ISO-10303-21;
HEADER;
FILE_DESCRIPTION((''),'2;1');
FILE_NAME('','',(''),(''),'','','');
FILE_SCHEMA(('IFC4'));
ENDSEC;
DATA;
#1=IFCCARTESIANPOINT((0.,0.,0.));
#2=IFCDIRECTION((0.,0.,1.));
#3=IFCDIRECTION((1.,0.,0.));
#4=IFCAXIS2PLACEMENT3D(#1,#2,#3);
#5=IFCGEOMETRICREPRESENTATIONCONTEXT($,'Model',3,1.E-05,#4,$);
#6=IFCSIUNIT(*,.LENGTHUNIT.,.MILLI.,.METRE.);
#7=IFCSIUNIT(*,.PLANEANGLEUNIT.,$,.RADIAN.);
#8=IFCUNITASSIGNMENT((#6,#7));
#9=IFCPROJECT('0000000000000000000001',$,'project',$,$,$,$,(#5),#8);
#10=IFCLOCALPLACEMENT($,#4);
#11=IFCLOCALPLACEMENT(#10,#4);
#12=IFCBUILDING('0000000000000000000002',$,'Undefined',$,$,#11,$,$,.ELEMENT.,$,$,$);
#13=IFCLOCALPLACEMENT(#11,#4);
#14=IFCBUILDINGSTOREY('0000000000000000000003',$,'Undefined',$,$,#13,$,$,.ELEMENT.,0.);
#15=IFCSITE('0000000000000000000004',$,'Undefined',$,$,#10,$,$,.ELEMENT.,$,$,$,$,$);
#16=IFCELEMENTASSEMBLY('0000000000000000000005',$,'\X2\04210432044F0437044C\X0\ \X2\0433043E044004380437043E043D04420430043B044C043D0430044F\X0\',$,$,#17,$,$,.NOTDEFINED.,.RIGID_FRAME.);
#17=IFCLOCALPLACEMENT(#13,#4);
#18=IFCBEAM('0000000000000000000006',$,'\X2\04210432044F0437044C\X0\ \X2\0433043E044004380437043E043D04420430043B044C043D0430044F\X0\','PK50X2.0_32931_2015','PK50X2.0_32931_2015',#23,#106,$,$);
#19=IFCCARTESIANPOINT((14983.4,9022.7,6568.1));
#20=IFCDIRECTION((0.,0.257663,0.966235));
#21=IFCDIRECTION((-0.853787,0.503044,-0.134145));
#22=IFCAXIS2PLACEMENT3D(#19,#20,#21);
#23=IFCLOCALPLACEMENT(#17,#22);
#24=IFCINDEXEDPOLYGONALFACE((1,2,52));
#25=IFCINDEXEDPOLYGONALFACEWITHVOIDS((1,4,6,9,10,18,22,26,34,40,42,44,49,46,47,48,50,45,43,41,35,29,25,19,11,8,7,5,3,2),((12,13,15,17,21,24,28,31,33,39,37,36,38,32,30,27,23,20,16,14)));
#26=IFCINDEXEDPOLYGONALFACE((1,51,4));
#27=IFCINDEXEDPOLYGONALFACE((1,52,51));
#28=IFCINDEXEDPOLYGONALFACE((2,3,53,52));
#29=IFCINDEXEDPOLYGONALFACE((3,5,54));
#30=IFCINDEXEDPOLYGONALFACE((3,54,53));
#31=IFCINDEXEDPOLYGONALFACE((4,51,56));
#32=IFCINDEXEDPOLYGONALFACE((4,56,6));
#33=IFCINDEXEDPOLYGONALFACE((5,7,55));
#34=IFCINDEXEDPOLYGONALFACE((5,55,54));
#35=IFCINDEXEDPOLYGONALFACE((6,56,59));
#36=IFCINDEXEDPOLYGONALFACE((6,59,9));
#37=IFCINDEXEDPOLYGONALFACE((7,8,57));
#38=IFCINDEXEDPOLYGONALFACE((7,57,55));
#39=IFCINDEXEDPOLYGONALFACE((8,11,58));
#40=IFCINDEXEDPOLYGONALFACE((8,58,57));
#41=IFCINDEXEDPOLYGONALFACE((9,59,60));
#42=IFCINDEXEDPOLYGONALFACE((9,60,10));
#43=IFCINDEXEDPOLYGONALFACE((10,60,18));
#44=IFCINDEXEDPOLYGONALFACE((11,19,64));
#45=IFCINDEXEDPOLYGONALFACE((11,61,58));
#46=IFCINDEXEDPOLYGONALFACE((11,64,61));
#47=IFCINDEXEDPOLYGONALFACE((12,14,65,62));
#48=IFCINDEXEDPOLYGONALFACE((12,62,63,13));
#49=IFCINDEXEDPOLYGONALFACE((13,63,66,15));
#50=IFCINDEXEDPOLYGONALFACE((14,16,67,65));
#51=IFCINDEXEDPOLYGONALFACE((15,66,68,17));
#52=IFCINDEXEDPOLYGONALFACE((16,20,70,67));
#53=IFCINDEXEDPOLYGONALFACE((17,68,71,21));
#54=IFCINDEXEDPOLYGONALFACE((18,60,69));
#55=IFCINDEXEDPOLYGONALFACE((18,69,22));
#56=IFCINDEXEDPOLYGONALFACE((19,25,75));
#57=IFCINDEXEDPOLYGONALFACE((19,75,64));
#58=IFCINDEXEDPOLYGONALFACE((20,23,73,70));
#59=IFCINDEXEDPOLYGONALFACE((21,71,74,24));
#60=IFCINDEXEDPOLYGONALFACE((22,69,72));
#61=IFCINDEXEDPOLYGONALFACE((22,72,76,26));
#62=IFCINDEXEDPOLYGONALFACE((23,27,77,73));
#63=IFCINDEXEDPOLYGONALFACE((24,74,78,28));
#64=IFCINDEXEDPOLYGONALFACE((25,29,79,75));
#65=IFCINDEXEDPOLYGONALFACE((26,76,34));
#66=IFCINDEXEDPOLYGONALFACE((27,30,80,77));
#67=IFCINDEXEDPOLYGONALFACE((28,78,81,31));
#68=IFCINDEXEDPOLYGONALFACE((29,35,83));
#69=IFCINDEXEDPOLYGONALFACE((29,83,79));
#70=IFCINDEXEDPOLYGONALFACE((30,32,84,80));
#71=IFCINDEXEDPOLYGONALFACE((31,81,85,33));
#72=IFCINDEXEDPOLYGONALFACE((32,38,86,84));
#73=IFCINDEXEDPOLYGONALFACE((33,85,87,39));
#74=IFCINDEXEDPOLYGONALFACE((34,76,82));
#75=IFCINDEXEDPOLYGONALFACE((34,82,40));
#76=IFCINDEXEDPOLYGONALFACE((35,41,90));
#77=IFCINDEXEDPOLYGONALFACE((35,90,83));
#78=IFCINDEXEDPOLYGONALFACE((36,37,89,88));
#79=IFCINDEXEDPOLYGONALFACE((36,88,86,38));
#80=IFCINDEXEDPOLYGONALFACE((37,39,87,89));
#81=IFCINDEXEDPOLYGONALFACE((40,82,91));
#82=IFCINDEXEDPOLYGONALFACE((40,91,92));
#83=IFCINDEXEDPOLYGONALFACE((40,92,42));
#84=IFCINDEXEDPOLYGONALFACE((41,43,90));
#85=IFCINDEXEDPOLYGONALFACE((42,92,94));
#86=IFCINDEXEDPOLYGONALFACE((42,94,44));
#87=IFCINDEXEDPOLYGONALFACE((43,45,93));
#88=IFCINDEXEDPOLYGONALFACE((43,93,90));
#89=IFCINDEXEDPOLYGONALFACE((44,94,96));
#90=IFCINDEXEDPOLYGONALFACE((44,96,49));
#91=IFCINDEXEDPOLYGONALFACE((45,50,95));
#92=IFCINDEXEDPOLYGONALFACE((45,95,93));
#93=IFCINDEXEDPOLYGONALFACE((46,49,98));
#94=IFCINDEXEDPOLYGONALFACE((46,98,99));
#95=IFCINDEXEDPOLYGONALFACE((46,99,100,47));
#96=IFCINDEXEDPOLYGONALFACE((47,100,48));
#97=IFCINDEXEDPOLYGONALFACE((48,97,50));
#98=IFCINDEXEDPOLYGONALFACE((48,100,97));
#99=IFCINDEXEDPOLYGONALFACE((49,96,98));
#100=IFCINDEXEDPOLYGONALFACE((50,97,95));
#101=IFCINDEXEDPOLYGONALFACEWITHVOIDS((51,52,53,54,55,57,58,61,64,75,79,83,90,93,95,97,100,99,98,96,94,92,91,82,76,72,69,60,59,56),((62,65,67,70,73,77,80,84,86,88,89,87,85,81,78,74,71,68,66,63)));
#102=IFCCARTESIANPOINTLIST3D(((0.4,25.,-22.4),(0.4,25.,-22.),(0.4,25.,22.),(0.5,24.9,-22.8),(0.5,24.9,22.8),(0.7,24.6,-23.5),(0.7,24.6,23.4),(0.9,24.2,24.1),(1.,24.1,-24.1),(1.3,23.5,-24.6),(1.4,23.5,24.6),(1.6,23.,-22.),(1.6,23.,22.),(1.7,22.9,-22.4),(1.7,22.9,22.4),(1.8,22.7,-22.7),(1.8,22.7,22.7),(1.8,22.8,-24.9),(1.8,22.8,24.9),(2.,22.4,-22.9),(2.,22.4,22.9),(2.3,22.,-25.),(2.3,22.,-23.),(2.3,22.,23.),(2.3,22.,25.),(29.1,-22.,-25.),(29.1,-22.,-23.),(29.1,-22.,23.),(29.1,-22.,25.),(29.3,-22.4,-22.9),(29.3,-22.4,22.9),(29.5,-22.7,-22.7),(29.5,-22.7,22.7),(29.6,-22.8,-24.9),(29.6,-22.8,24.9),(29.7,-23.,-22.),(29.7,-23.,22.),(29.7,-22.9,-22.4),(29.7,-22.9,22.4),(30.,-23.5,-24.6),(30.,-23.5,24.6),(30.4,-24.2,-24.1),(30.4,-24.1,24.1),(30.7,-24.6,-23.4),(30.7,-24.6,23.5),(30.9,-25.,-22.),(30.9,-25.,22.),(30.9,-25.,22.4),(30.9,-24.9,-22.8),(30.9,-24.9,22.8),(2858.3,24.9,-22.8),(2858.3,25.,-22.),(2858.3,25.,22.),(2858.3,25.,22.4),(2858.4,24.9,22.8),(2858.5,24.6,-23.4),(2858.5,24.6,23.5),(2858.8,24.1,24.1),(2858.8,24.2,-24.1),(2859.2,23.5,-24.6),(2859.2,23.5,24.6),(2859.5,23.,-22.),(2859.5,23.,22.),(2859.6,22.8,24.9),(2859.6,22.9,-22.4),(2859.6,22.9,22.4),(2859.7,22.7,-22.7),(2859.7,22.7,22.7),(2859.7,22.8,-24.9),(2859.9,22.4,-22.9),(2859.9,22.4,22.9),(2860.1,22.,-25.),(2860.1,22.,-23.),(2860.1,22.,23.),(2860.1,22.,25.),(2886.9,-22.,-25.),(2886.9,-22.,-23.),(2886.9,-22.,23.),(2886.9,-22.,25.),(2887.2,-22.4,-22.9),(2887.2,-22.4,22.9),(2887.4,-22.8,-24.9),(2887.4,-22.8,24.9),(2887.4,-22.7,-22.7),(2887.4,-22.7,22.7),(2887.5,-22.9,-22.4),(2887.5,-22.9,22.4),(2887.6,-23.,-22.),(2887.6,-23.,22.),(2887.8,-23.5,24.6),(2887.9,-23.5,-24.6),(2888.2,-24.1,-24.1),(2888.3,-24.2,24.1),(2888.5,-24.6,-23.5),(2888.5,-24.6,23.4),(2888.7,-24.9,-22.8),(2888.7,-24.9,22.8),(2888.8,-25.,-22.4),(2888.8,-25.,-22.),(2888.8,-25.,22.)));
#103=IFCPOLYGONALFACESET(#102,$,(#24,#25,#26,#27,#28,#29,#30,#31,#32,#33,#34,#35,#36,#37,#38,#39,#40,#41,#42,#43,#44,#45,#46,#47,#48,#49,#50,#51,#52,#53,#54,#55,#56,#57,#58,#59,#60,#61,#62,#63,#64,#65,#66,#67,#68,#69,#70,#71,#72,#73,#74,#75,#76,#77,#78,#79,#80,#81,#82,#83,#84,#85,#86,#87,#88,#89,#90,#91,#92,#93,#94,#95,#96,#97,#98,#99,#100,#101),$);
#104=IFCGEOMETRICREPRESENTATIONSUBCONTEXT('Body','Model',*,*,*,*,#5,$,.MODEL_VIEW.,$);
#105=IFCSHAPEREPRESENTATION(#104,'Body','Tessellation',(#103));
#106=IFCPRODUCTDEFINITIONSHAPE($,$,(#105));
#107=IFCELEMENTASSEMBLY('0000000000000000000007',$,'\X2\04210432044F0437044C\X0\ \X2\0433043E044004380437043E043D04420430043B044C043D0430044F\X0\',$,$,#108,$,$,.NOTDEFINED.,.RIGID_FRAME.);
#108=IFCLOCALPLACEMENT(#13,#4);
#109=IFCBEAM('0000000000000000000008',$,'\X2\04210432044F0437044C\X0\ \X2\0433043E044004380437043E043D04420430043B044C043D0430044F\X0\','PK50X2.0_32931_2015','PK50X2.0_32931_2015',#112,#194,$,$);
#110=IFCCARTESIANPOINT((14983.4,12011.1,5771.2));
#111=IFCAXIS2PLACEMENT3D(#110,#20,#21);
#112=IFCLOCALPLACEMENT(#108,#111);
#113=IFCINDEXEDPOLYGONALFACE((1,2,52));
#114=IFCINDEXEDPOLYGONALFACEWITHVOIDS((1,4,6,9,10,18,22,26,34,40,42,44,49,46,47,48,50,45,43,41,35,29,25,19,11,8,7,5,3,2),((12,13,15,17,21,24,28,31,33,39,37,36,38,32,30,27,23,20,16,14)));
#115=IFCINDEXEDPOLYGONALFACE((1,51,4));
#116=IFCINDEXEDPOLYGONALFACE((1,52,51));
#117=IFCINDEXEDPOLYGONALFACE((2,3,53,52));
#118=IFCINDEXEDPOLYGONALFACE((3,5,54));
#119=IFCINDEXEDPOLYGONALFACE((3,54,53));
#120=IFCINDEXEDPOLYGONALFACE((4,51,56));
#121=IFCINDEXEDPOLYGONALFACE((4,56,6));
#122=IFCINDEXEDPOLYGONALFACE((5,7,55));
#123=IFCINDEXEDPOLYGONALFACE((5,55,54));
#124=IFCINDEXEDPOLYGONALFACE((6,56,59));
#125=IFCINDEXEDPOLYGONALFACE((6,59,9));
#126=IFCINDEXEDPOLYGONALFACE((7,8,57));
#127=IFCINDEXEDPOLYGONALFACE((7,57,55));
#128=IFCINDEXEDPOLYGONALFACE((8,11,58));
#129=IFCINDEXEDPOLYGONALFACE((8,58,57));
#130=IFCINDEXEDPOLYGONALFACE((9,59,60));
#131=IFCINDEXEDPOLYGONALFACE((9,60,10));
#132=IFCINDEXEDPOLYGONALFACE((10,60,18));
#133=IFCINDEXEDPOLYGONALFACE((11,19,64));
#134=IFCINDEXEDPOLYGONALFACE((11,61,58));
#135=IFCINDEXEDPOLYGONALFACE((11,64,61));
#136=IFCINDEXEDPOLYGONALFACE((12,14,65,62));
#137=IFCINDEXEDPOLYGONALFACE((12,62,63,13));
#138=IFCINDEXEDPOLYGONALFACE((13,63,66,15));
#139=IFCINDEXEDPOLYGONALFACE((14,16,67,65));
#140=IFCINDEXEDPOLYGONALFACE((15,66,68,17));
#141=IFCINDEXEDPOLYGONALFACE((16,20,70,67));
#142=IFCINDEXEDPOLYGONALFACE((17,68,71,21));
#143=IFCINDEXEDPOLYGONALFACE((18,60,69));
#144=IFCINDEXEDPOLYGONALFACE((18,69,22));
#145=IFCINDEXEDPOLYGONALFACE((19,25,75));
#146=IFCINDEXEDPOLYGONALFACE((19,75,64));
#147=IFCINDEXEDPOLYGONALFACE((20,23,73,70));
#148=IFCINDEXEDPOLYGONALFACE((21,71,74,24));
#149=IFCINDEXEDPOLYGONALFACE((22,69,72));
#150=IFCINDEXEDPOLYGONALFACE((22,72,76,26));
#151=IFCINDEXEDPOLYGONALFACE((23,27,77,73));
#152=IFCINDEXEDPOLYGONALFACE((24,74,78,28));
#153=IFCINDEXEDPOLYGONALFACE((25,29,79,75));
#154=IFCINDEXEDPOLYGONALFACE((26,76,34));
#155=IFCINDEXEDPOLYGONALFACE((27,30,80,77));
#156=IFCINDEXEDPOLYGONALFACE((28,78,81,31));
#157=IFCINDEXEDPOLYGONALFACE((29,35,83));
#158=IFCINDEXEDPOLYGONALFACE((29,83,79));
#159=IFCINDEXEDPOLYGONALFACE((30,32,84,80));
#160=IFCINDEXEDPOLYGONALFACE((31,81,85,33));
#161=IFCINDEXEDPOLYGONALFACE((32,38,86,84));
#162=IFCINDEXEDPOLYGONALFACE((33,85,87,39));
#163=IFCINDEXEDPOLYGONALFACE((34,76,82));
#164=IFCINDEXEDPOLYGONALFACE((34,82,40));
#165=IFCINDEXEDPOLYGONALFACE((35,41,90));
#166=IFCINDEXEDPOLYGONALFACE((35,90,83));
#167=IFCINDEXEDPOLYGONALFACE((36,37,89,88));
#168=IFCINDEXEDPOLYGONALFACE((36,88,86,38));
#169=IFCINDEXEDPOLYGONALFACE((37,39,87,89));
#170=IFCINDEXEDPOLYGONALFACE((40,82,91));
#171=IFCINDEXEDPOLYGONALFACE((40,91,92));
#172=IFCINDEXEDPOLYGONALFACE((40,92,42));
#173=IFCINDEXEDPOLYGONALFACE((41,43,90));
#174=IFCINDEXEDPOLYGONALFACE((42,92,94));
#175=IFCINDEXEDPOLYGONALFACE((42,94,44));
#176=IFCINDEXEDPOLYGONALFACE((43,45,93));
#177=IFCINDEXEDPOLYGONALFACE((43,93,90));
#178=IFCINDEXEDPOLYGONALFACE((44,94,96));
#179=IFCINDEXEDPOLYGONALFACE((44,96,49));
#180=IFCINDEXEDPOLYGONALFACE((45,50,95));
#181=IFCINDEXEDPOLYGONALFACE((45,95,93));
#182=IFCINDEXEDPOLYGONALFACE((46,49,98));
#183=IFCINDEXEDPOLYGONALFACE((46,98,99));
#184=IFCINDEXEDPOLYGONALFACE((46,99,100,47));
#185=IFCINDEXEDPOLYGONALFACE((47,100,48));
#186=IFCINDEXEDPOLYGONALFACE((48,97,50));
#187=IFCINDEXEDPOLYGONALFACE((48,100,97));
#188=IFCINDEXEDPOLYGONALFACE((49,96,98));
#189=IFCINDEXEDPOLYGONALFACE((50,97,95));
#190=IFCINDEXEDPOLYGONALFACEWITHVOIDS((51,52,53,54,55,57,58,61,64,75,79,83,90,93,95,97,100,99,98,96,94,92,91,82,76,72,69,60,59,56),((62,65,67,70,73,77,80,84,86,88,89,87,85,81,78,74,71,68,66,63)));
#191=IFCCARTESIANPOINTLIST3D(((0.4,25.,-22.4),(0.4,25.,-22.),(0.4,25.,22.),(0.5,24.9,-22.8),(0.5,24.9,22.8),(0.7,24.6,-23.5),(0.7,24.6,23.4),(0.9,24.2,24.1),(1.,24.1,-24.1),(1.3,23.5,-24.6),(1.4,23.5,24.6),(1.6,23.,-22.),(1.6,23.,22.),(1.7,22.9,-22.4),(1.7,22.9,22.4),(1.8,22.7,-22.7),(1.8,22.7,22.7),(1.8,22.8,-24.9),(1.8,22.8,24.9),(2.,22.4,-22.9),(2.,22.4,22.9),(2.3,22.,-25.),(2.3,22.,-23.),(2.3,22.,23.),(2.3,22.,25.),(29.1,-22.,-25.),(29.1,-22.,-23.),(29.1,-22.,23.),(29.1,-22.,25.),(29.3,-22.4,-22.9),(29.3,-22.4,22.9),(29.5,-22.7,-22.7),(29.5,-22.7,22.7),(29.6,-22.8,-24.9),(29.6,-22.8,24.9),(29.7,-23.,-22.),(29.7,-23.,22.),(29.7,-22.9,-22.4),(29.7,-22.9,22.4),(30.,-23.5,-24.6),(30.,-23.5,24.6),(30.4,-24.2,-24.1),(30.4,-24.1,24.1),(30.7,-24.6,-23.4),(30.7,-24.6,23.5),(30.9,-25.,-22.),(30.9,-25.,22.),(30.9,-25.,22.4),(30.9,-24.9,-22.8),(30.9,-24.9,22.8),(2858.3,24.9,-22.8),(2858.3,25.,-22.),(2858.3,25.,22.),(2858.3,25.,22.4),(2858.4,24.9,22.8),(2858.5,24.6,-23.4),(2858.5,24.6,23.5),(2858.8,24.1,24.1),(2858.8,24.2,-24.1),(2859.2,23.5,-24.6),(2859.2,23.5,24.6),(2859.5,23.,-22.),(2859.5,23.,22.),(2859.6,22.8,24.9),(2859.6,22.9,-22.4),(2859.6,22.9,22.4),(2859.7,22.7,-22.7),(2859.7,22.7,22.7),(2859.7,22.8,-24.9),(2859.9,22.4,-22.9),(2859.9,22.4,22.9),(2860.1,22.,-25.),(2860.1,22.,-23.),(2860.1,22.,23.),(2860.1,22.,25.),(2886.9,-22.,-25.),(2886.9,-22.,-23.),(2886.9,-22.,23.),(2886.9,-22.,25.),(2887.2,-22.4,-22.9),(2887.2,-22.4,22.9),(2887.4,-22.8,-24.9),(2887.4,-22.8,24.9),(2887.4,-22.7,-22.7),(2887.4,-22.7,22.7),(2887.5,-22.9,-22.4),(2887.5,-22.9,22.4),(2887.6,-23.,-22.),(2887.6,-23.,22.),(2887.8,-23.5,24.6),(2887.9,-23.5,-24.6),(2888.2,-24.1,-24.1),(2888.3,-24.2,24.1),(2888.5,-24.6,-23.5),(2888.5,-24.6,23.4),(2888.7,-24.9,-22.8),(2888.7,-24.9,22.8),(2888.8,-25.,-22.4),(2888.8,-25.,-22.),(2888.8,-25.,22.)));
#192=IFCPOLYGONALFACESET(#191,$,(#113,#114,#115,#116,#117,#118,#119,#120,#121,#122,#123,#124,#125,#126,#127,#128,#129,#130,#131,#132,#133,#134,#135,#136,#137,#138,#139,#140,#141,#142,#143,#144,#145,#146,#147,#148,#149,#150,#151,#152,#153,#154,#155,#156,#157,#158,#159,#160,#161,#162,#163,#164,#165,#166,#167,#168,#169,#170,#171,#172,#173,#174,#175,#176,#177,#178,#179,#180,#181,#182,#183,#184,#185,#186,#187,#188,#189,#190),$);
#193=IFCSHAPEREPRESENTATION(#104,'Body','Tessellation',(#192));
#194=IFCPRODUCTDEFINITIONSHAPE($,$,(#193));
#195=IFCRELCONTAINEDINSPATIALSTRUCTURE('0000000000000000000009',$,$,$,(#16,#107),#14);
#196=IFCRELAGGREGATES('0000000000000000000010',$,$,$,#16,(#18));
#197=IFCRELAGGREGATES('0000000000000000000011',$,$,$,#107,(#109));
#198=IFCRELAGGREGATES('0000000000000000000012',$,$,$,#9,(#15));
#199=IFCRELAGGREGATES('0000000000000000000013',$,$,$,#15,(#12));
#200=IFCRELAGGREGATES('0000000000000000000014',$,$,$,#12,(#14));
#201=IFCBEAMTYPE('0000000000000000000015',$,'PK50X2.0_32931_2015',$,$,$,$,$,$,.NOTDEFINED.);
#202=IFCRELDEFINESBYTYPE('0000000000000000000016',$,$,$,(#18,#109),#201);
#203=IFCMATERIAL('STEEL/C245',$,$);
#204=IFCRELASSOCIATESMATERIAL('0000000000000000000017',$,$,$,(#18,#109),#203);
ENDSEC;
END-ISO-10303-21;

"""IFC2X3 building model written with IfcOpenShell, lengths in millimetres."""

from ifc_helpers import new_model, si_unit, frame, origin_with_axes, origin_2d_with_axis, place, context, subcontext, project, spatial, hollow_rectangle, extrude, clip, halfspace, material, type_object, element, aggregate, save


model = new_model("IFC2X3")

# Units and contexts
model_context = context("Model", 3, precision=1e-05, world=origin_with_axes())
body_context = subcontext(model_context, "Body", "Model", "MODEL_VIEW")
ifc_project = project(units=[si_unit("LENGTHUNIT", "METRE", prefix="MILLI"), si_unit("PLANEANGLEUNIT", "RADIAN")], contexts=[model_context])

# Site, building, storey
site_placement = place(None, origin_with_axes())
site = spatial("IfcSite", under=ifc_project, at=site_placement, Name="Undefined", CompositionType="ELEMENT")
building_placement = place(site_placement, origin_with_axes())
building = spatial("IfcBuilding", under=site, at=building_placement, Name="Undefined", CompositionType="ELEMENT")
storey_placement = place(building_placement, origin_with_axes())
storey = spatial("IfcBuildingStorey", under=building, at=storey_placement, Name="Undefined", CompositionType="ELEMENT", Elevation=0.0)

# Shared definitions
ifc_material_1 = material(Name="STEEL/C245")

# Element assemblies, beams
beam_type_1 = type_object("IfcBeamType", Name="PK50X2.0_32931_2015", PredefinedType="NOTDEFINED")
assembly_1_placement = place(storey_placement, origin_with_axes())
assembly_1 = element("IfcElementAssembly", 1, at=assembly_1_placement, inside=storey, Name="Связь горизонтальная", AssemblyPlace="NOTDEFINED", PredefinedType="RIGID_FRAME")
beam_1_placement = place(assembly_1_placement, frame((14983.4, 9022.7, 6568.1), z_axis=(0.0, 0.257663, 0.966235), x_axis=(-0.853787, 0.503044, -0.134145)))
beam_1 = element("IfcBeam", 2, at=beam_1_placement, type_object=beam_type_1, material=ifc_material_1, Name="Связь горизонтальная", Description="PK50X2.0_32931_2015", ObjectType="PK50X2.0_32931_2015", context=body_context, shape_type="Clipping", body=[
    clip(clip(extrude(hollow_rectangle(XDim=50.0, YDim=50.0, WallThickness=2.0, InnerFilletRadius=1.0, OuterFilletRadius=3.0, at=origin_2d_with_axis()), frame((2917.4, 0.0, 0.0), z_axis=(-1.0, 0.0, 0.0), x_axis=(0.0, -1.0, 0.0)), (0.0, 0.0, 1.0), 2945.6), halfspace(frame((2920.7, -77.3, 25.0), z_axis=(-0.853787, -0.520623, 0.0), x_axis=(-0.520623, 0.853787, 0.0)), True)), halfspace(frame((48.4, -53.7, 25.0), z_axis=(0.853787, 0.520623, 0.0), x_axis=(0.520623, -0.853787, 0.0)), True)),
])
aggregate(assembly_1, [beam_1])
assembly_2_placement = place(storey_placement, origin_with_axes())
assembly_2 = element("IfcElementAssembly", 3, at=assembly_2_placement, inside=storey, Name="Связь горизонтальная", AssemblyPlace="NOTDEFINED", PredefinedType="RIGID_FRAME")
beam_2_placement = place(assembly_2_placement, frame((14983.4, 12011.1, 5771.2), z_axis=(0.0, 0.257663, 0.966235), x_axis=(-0.853787, 0.503044, -0.134145)))
beam_2 = element("IfcBeam", 4, at=beam_2_placement, type_object=beam_type_1, material=ifc_material_1, Name="Связь горизонтальная", Description="PK50X2.0_32931_2015", ObjectType="PK50X2.0_32931_2015", context=body_context, shape_type="Clipping", body=[
    clip(clip(extrude(hollow_rectangle(XDim=50.0, YDim=50.0, WallThickness=2.0, InnerFilletRadius=1.0, OuterFilletRadius=3.0, at=origin_2d_with_axis()), frame((2917.4, 0.0, 0.0), z_axis=(-1.0, 0.0, 0.0), x_axis=(0.0, -1.0, 0.0)), (0.0, 0.0, 1.0), 2945.6), halfspace(frame((2920.7, -77.3, 25.0), z_axis=(-0.853787, -0.520623, 0.0), x_axis=(-0.520623, 0.853787, 0.0)), True)), halfspace(frame((48.4, -53.7, 25.0), z_axis=(0.853787, 0.520623, 0.0), x_axis=(0.520623, -0.853787, 0.0)), True)),
])
aggregate(assembly_2, [beam_2])

save(model, "model.ifc")
